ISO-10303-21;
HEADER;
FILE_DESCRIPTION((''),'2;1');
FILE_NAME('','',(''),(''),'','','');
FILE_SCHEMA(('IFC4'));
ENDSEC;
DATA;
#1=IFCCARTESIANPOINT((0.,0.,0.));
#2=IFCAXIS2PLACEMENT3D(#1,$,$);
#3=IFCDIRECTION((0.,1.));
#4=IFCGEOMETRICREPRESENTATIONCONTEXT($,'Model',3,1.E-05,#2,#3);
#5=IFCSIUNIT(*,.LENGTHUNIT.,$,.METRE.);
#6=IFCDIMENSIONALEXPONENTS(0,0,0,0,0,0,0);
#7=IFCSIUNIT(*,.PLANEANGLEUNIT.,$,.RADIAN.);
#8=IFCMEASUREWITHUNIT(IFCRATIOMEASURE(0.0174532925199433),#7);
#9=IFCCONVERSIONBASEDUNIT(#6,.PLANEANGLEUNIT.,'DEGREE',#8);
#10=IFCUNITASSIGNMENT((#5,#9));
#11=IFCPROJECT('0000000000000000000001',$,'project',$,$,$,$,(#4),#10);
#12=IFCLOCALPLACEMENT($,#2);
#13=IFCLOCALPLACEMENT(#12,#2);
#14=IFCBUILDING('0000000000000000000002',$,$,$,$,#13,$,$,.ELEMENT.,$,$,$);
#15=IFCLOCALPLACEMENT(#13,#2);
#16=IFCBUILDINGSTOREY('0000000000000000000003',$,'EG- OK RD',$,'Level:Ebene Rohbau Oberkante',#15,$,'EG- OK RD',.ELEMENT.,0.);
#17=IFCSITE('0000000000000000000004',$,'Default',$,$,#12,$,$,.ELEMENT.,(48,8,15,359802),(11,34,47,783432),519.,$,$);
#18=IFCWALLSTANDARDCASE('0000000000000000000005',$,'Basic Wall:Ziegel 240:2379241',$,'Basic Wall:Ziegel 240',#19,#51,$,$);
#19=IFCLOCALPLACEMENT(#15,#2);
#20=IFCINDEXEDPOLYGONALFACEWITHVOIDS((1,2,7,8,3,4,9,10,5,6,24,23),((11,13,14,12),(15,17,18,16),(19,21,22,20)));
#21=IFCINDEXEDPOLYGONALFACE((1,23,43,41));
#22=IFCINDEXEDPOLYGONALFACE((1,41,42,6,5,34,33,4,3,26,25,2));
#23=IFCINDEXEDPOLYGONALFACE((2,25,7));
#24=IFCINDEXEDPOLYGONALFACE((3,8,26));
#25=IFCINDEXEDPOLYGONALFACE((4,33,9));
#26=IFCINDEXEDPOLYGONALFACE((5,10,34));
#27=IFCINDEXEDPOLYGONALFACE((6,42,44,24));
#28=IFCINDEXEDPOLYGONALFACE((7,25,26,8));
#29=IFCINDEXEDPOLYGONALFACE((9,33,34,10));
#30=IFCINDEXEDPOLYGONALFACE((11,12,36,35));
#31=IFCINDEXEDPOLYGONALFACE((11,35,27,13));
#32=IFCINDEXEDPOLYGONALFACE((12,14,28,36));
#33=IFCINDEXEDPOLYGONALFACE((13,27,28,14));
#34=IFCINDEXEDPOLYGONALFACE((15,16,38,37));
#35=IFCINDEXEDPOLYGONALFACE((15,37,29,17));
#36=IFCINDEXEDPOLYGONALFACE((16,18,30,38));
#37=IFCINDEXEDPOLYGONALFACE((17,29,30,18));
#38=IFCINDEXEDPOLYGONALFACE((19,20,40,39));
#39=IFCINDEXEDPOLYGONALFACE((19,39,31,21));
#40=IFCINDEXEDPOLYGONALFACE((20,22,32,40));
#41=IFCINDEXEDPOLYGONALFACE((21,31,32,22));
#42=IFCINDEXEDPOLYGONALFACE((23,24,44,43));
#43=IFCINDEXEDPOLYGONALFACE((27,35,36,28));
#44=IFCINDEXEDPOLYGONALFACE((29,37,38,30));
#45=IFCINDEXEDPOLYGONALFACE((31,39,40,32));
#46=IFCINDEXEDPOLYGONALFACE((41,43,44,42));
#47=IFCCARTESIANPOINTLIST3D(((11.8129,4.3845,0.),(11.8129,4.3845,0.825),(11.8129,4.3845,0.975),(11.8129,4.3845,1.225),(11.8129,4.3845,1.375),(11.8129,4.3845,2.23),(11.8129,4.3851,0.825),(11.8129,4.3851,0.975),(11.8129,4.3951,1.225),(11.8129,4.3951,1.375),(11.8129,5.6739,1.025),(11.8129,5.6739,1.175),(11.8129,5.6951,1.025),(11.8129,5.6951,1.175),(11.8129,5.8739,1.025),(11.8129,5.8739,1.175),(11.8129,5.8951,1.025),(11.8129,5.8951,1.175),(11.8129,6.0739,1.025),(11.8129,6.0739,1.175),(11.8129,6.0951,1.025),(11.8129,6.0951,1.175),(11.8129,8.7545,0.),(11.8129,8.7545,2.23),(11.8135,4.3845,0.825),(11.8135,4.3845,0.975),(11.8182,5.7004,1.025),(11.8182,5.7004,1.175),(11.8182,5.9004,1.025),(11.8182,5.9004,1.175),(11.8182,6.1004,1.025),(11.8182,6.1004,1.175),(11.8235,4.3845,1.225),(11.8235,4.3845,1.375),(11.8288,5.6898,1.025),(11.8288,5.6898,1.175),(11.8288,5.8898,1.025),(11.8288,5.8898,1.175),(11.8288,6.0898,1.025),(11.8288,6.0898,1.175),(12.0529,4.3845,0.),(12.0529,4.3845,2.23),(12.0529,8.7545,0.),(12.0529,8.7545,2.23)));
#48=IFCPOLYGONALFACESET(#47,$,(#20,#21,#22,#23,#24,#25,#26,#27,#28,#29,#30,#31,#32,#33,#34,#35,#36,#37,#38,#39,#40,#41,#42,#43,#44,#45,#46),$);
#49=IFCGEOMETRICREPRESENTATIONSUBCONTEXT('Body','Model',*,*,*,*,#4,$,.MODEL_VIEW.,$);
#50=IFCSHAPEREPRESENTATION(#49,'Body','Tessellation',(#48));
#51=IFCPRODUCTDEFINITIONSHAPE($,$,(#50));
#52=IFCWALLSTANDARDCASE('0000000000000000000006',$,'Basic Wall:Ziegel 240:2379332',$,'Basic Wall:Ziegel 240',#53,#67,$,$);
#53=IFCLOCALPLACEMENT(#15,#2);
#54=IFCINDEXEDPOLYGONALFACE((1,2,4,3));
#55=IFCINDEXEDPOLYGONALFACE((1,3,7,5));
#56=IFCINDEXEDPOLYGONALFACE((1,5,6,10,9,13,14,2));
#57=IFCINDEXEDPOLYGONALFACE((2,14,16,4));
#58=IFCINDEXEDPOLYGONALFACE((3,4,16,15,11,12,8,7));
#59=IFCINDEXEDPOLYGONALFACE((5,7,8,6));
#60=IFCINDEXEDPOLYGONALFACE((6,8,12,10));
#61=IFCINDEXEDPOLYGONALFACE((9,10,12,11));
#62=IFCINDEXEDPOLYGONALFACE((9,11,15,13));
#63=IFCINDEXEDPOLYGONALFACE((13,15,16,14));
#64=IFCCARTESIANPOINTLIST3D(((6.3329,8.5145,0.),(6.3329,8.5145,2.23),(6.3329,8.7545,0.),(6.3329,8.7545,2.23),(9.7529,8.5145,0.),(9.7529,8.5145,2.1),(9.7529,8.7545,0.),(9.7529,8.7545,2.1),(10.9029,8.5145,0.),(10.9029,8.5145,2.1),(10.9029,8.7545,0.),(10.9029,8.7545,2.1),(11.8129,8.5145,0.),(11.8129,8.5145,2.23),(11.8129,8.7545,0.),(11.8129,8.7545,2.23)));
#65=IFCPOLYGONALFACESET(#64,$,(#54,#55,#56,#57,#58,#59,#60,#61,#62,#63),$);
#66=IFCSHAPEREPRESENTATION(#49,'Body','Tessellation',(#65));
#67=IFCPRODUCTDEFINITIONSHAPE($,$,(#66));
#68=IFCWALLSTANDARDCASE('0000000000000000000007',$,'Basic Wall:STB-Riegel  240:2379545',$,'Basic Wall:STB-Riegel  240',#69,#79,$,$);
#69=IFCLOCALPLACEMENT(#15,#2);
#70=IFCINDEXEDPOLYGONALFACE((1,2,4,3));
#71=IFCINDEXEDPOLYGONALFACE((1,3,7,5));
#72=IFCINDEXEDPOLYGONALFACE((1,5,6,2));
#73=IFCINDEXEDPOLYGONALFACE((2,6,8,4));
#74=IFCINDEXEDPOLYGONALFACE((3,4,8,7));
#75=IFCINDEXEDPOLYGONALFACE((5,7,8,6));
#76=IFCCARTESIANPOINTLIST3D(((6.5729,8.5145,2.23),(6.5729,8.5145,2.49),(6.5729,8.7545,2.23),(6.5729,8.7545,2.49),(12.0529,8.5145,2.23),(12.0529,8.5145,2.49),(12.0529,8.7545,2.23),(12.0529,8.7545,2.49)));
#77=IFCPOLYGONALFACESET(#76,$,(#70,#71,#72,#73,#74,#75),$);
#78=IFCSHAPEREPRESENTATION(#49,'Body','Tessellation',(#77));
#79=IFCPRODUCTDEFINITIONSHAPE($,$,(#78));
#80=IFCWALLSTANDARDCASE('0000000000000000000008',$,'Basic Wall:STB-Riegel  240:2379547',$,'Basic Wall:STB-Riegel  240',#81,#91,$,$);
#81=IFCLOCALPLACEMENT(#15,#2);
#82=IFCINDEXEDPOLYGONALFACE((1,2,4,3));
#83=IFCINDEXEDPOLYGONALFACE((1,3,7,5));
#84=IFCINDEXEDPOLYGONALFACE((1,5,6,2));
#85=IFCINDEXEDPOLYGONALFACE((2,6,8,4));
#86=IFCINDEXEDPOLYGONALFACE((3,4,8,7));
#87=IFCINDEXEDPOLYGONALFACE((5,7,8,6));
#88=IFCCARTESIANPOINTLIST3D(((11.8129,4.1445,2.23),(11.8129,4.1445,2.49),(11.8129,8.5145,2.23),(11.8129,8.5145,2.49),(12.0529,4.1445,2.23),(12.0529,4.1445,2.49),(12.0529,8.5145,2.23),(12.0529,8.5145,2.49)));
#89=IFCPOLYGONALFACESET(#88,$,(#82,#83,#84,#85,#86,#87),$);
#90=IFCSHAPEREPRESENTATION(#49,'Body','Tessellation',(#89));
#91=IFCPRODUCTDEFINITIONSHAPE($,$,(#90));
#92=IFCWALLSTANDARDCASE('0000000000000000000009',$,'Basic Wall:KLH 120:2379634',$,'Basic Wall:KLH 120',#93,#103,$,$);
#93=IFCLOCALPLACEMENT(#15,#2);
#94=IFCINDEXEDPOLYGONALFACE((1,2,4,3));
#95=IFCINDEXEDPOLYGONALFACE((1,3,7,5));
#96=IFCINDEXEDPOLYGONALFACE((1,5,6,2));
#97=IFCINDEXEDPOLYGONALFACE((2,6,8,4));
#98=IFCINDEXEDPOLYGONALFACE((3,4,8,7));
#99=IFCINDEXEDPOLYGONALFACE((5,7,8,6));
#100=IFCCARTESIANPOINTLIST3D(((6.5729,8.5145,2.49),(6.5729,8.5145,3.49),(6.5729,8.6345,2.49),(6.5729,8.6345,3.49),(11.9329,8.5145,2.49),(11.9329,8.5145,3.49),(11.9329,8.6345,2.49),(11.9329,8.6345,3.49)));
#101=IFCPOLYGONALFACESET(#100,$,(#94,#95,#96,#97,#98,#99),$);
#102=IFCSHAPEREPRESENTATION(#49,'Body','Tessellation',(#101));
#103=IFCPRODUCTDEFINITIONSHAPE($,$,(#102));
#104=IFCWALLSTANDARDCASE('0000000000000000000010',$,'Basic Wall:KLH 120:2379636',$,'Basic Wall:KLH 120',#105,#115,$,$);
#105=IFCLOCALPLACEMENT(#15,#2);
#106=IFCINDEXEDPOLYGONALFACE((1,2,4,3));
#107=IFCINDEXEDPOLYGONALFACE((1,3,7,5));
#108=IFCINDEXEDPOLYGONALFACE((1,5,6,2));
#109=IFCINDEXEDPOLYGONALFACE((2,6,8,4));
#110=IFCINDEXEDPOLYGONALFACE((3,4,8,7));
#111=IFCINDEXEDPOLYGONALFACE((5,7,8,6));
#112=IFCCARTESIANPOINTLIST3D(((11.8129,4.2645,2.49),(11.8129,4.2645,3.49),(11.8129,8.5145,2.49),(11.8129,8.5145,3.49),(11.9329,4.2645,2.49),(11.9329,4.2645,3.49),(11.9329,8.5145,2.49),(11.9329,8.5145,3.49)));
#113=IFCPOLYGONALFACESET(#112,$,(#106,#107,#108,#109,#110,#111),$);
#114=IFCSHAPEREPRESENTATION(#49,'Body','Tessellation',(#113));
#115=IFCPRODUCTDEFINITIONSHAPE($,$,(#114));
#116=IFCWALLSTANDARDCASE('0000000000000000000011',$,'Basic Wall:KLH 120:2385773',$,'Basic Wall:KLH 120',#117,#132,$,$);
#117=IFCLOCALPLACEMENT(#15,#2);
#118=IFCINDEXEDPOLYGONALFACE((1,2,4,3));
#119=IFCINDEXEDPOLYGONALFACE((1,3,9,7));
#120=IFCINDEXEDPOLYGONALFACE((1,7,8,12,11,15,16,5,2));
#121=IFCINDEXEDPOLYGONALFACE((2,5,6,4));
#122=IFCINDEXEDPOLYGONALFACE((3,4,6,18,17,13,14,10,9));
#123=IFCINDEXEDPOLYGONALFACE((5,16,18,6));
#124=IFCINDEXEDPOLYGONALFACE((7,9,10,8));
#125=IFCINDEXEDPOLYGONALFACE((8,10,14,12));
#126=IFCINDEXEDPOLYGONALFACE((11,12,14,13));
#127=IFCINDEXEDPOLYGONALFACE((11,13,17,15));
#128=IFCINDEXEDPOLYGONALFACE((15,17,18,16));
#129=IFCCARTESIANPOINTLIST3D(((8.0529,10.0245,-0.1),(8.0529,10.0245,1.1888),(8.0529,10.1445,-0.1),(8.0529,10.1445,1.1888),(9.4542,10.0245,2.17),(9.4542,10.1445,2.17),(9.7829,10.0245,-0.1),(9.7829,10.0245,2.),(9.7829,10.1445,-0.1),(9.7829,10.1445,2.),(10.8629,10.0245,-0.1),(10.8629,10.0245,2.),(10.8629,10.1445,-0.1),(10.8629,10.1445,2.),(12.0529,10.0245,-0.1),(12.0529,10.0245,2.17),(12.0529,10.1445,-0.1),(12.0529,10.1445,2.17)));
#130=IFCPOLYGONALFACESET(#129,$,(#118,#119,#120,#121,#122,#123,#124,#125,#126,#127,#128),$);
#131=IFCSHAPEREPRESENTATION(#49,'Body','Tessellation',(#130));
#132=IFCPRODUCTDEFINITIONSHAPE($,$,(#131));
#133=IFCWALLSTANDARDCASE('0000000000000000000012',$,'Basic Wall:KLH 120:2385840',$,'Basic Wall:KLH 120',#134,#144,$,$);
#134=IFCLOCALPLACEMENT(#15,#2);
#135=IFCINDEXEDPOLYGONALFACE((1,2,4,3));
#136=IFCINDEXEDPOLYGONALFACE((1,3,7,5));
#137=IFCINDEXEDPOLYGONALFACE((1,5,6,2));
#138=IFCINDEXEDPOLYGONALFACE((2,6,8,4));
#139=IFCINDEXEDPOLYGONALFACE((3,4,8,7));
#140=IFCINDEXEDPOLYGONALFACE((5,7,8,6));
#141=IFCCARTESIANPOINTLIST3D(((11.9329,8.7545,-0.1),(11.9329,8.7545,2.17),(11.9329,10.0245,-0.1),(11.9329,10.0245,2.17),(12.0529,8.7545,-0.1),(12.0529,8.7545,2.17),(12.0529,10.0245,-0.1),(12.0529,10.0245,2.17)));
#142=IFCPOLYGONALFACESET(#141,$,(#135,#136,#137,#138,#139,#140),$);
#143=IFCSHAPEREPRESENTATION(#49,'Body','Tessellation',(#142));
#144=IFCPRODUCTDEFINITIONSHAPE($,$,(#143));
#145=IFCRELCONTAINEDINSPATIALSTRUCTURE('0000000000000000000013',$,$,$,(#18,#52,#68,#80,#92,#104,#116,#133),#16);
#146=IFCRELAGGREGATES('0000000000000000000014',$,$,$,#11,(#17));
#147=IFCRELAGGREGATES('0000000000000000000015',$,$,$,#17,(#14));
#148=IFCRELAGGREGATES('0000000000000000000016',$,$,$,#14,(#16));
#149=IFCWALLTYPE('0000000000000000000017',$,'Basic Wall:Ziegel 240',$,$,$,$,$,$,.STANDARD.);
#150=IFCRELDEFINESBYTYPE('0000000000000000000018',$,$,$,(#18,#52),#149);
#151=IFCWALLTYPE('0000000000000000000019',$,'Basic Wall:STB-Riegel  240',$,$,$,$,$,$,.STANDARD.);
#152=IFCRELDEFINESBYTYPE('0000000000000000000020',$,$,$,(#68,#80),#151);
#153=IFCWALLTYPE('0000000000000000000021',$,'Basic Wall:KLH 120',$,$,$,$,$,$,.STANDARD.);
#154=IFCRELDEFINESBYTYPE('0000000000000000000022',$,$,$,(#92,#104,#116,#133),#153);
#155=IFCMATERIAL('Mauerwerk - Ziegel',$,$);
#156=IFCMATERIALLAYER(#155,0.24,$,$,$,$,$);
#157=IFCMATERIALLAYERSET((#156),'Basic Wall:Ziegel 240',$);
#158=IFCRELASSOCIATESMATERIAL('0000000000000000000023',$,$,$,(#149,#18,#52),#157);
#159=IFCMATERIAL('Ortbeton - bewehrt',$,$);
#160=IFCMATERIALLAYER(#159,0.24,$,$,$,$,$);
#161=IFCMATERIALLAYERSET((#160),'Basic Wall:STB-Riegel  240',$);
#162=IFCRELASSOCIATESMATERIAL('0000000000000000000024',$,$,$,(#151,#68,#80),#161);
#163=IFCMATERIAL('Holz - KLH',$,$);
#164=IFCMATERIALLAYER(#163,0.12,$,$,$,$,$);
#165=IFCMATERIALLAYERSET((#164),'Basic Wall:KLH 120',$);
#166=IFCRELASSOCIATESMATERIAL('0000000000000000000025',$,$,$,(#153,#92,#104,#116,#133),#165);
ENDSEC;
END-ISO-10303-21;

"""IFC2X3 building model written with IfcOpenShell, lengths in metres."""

from ifc_helpers import new_model, entity, si_unit, converted_unit, direction, frame, frame_2d, origin, place, context, subcontext, project, spatial, polyline, rectangle, extrude, clip, bounded_halfspace, material, layer, layer_set, layer_usage, type_object, element, save


model = new_model("IFC2X3")

# Units and contexts
model_context = context("Model", 3, precision=1e-05, world=origin(), true_north=direction((0.0, 1.0)))
body_context = subcontext(model_context, "Body", "Model", "MODEL_VIEW")
ifc_project = project(units=[si_unit("LENGTHUNIT", "METRE"), converted_unit("PLANEANGLEUNIT", "DEGREE", entity("IfcRatioMeasure", 0.0174532925199433), si_unit("PLANEANGLEUNIT", "RADIAN"), dimensions=[0, 0, 0, 0, 0, 0, 0])], contexts=[model_context])

# Site, building, storey
site_placement = place(None, origin())
site = spatial("IfcSite", under=ifc_project, at=site_placement, Name="Default", CompositionType="ELEMENT", RefLatitude=(48, 8, 15, 359802), RefLongitude=(11, 34, 47, 783432), RefElevation=519.0)
building_placement = place(site_placement, origin())
building = spatial("IfcBuilding", under=site, at=building_placement, CompositionType="ELEMENT")
storey_placement = place(building_placement, origin())
storey = spatial("IfcBuildingStorey", under=building, at=storey_placement, Name="EG- OK RD", ObjectType="Level:Ebene Rohbau Oberkante", LongName="EG- OK RD", CompositionType="ELEMENT", Elevation=0.0)

# Wall, openings
ifc_material_1 = material(Name="Mauerwerk - Ziegel")
ifc_layer_1 = layer(ifc_material_1, 0.24)
ifc_layer_set_1 = layer_set([ifc_layer_1], Name="Basic Wall:Ziegel 240")
ifc_layer_usage_1 = layer_usage(ifc_layer_set_1, "AXIS2", "POSITIVE", -0.12)
wall_type_1 = type_object("IfcWallType", Name="Basic Wall:Ziegel 240", PredefinedType="STANDARD", material=ifc_layer_set_1)
wall_1_placement = place(storey_placement, frame((11.9329, 4.3845, 0.0), z_axis=(0.0, 0.0, 1.0), x_axis=(0.0, 1.0, 0.0)))
wall_1 = element("IfcWallStandardCase", 1, at=wall_1_placement, inside=storey, type_object=wall_type_1, material=ifc_layer_usage_1, Name="Basic Wall:Ziegel 240:2379241", ObjectType="Basic Wall:Ziegel 240", context=body_context, shape_type="SweptSolid", body=[
    extrude(rectangle(XDim=4.37, YDim=0.24, at=frame_2d((2.185, 0.0), x_axis=(-1.0, 0.0))), origin(), (0.0, 0.0, 1.0), 2.23),
])
opening_1_placement = place(wall_1_placement, origin())
element("IfcOpeningElement", 2, at=opening_1_placement, cuts=wall_1, ObjectType="Recess", context=body_context, shape_type="SweptSolid", body=[
    extrude(rectangle(XDim=0.15, YDim=0.0285, at=frame_2d((0.0, 0.0), x_axis=(0.0, 1.0))), frame((0.0048, 0.1242, 0.9), z_axis=(-0.707107, 0.707107, 0.0), x_axis=(-0.707107, -0.707107, 0.0)), (0.0, 0.0, 1.0), 0.015),
])
opening_2_placement = place(wall_1_placement, origin())
element("IfcOpeningElement", 3, at=opening_2_placement, cuts=wall_1, ObjectType="Recess", context=body_context, shape_type="SweptSolid", body=[
    extrude(rectangle(XDim=0.15, YDim=0.0285, at=frame_2d((0.0, 0.0), x_axis=(0.0, 1.0))), frame((0.0048, 0.1142, 1.3), z_axis=(-0.707107, 0.707107, 0.0), x_axis=(-0.707107, -0.707107, 0.0)), (0.0, 0.0, 1.0), 0.015),
])
opening_3_placement = place(wall_1_placement, origin())
element("IfcOpeningElement", 4, at=opening_3_placement, cuts=wall_1, ObjectType="Recess", context=body_context, shape_type="SweptSolid", body=[
    extrude(rectangle(XDim=0.15, YDim=0.0285, at=frame_2d((0.0, 0.0), x_axis=(0.0, 1.0))), frame((0.1195, 0.2289, 1.1), z_axis=(-0.707107, 0.707107, 0.0), x_axis=(-0.707107, -0.707107, 0.0)), (0.0, 0.0, 1.0), 0.015),
])
opening_4_placement = place(wall_1_placement, origin())
element("IfcOpeningElement", 5, at=opening_4_placement, cuts=wall_1, ObjectType="Recess", context=body_context, shape_type="SweptSolid", body=[
    extrude(rectangle(XDim=0.15, YDim=0.0285, at=frame_2d((0.0, 0.0), x_axis=(0.0, 1.0))), frame((1.2952, 0.1142, 1.1), z_axis=(0.707107, 0.707107, 0.0), x_axis=(0.707107, -0.707107, 0.0)), (0.0, 0.0, 1.0), 0.015),
])
opening_5_placement = place(wall_1_placement, origin())
element("IfcOpeningElement", 6, at=opening_5_placement, cuts=wall_1, ObjectType="Recess", context=body_context, shape_type="SweptSolid", body=[
    extrude(rectangle(XDim=0.15, YDim=0.0285, at=frame_2d((0.0, 0.0), x_axis=(0.0, 1.0))), frame((1.4952, 0.1142, 1.1), z_axis=(0.707107, 0.707107, 0.0), x_axis=(0.707107, -0.707107, 0.0)), (0.0, 0.0, 1.0), 0.015),
])
opening_6_placement = place(wall_1_placement, origin())
element("IfcOpeningElement", 7, at=opening_6_placement, cuts=wall_1, ObjectType="Recess", context=body_context, shape_type="SweptSolid", body=[
    extrude(rectangle(XDim=0.15, YDim=0.0285, at=frame_2d((0.0, 0.0), x_axis=(0.0, 1.0))), frame((1.6952, 0.1142, 1.1), z_axis=(0.707107, 0.707107, 0.0), x_axis=(0.707107, -0.707107, 0.0)), (0.0, 0.0, 1.0), 0.015),
])

# Wall, opening
ifc_layer_usage_2 = layer_usage(ifc_layer_set_1, "AXIS2", "POSITIVE", -0.12)
wall_2_placement = place(storey_placement, frame((11.8129, 8.6345, 0.0), z_axis=(0.0, 0.0, 1.0), x_axis=(-1.0, 0.0, 0.0)))
wall_2 = element("IfcWallStandardCase", 8, at=wall_2_placement, inside=storey, type_object=wall_type_1, material=ifc_layer_usage_2, Name="Basic Wall:Ziegel 240:2379332", ObjectType="Basic Wall:Ziegel 240", context=body_context, shape_type="SweptSolid", body=[
    extrude(rectangle(XDim=5.48, YDim=0.24, at=frame_2d((2.74, 0.0), x_axis=(-1.0, 0.0))), origin(), (0.0, 0.0, 1.0), 2.23),
])
opening_7_placement = place(wall_2_placement, frame((0.91, -0.12, 0.0)))
element("IfcOpeningElement", 9, at=opening_7_placement, cuts=wall_2, ObjectType="Opening", context=body_context, shape_type="SweptSolid", body=[
    extrude(rectangle(XDim=2.1, YDim=1.15, at=frame_2d((1.05, 0.575), x_axis=(-1.0, 0.0))), frame((0.0, 0.0, 0.0), z_axis=(0.0, 1.0, 0.0), x_axis=(0.0, 0.0, 1.0)), (0.0, 0.0, 1.0), 0.24),
])

# Walls
ifc_material_2 = material(Name="Ortbeton - bewehrt")
ifc_layer_2 = layer(ifc_material_2, 0.24)
ifc_layer_set_2 = layer_set([ifc_layer_2], Name="Basic Wall:STB-Riegel  240")
ifc_layer_usage_3 = layer_usage(ifc_layer_set_2, "AXIS2", "NEGATIVE", 0.12)
wall_type_2 = type_object("IfcWallType", Name="Basic Wall:STB-Riegel  240", PredefinedType="STANDARD", material=ifc_layer_set_2)
wall_3_placement = place(storey_placement, frame((12.0529, 8.6345, 2.23), z_axis=(0.0, 0.0, 1.0), x_axis=(-1.0, 0.0, 0.0)))
element("IfcWallStandardCase", 10, at=wall_3_placement, inside=storey, type_object=wall_type_2, material=ifc_layer_usage_3, Name="Basic Wall:STB-Riegel  240:2379545", ObjectType="Basic Wall:STB-Riegel  240", context=body_context, shape_type="SweptSolid", body=[
    extrude(rectangle(XDim=5.48, YDim=0.24, at=frame_2d((2.74, 0.0), x_axis=(-1.0, 0.0))), origin(), (0.0, 0.0, 1.0), 0.26),
])
ifc_layer_usage_4 = layer_usage(ifc_layer_set_2, "AXIS2", "NEGATIVE", 0.12)
wall_4_placement = place(storey_placement, frame((11.9329, 4.1445, 2.23), z_axis=(0.0, 0.0, 1.0), x_axis=(0.0, 1.0, 0.0)))
element("IfcWallStandardCase", 11, at=wall_4_placement, inside=storey, type_object=wall_type_2, material=ifc_layer_usage_4, Name="Basic Wall:STB-Riegel  240:2379547", ObjectType="Basic Wall:STB-Riegel  240", context=body_context, shape_type="SweptSolid", body=[
    extrude(rectangle(XDim=4.37, YDim=0.24, at=frame_2d((2.185, 0.0), x_axis=(-1.0, 0.0))), origin(), (0.0, 0.0, 1.0), 0.26),
])
ifc_material_3 = material(Name="Holz - KLH")
ifc_layer_3 = layer(ifc_material_3, 0.12)
ifc_layer_set_3 = layer_set([ifc_layer_3], Name="Basic Wall:KLH 120")
ifc_layer_usage_5 = layer_usage(ifc_layer_set_3, "AXIS2", "NEGATIVE", 0.06)
wall_type_3 = type_object("IfcWallType", Name="Basic Wall:KLH 120", PredefinedType="STANDARD", material=ifc_layer_set_3)
wall_5_placement = place(storey_placement, frame((11.9329, 8.5745, 2.49), z_axis=(0.0, 0.0, 1.0), x_axis=(-1.0, 0.0, 0.0)))
element("IfcWallStandardCase", 12, at=wall_5_placement, inside=storey, type_object=wall_type_3, material=ifc_layer_usage_5, Name="Basic Wall:KLH 120:2379634", ObjectType="Basic Wall:KLH 120", context=body_context, shape_type="SweptSolid", body=[
    extrude(rectangle(XDim=5.36, YDim=0.12, at=frame_2d((2.68, 0.0), x_axis=(-1.0, 0.0))), origin(), (0.0, 0.0, 1.0), 1.0),
])
ifc_layer_usage_6 = layer_usage(ifc_layer_set_3, "AXIS2", "NEGATIVE", 0.06)
wall_6_placement = place(storey_placement, frame((11.8729, 4.2645, 2.49), z_axis=(0.0, 0.0, 1.0), x_axis=(0.0, 1.0, 0.0)))
element("IfcWallStandardCase", 13, at=wall_6_placement, inside=storey, type_object=wall_type_3, material=ifc_layer_usage_6, Name="Basic Wall:KLH 120:2379636", ObjectType="Basic Wall:KLH 120", context=body_context, shape_type="SweptSolid", body=[
    extrude(rectangle(XDim=4.25, YDim=0.12, at=frame_2d((2.125, 0.0), x_axis=(-1.0, 0.0))), origin(), (0.0, 0.0, 1.0), 1.0),
])

# Wall, opening
ifc_layer_usage_7 = layer_usage(ifc_layer_set_3, "AXIS2", "POSITIVE", -0.06)
wall_7_placement = place(storey_placement, frame((12.0529, 10.0845, -0.1), z_axis=(0.0, 0.0, 1.0), x_axis=(-1.0, 0.0, 0.0)))
wall_7 = element("IfcWallStandardCase", 14, at=wall_7_placement, inside=storey, type_object=wall_type_3, material=ifc_layer_usage_7, Name="Basic Wall:KLH 120:2385773", ObjectType="Basic Wall:KLH 120", context=body_context, shape_type="Clipping", body=[
    clip(clip(extrude(rectangle(XDim=4.0, YDim=0.12, at=frame_2d((2.0, 0.0), x_axis=(-1.0, 0.0))), origin(), (0.0, 0.0, 1.0), 2.27), bounded_halfspace(frame((0.0, 0.06, 2.27), z_axis=(0.0, 0.0, -1.0), x_axis=(0.0, 1.0, 0.0)), True, frame((0.0, 0.06, 2.27)), polyline([(0.0, 0.0), (0.0, -0.12), (2.5987, -0.12), (2.5987, 0.0), (0.12, 0.0), (0.0, 0.0)]))), bounded_halfspace(frame((4.0, -0.06, 1.2888), z_axis=(-0.573576, 0.0, -0.819152), x_axis=(0.0, 1.0, 0.0)), True, frame((4.0, -0.06, 1.2888)), polyline([(0.0, 0.0), (0.0, 0.12), (-0.12, 0.12), (-1.4013, 0.12), (-1.4013, 0.0), (0.0, 0.0)]))),
])
opening_8_placement = place(wall_7_placement, frame((1.19, -0.06, 0.0)))
element("IfcOpeningElement", 15, at=opening_8_placement, cuts=wall_7, ObjectType="Opening", context=body_context, shape_type="SweptSolid", body=[
    extrude(rectangle(XDim=2.1, YDim=1.08, at=frame_2d((1.05, 0.54), x_axis=(-1.0, 0.0))), frame((0.0, 0.0, 0.0), z_axis=(0.0, 1.0, 0.0), x_axis=(0.0, 0.0, 1.0)), (0.0, 0.0, 1.0), 0.12),
])

# Wall
ifc_layer_usage_8 = layer_usage(ifc_layer_set_3, "AXIS2", "POSITIVE", -0.06)
wall_8_placement = place(storey_placement, frame((11.9929, 8.7545, -0.1), z_axis=(0.0, 0.0, 1.0), x_axis=(0.0, 1.0, 0.0)))
element("IfcWallStandardCase", 16, at=wall_8_placement, inside=storey, type_object=wall_type_3, material=ifc_layer_usage_8, Name="Basic Wall:KLH 120:2385840", ObjectType="Basic Wall:KLH 120", context=body_context, shape_type="Clipping", body=[
    clip(extrude(rectangle(XDim=1.27, YDim=0.12, at=frame_2d((0.635, 0.0), x_axis=(-1.0, 0.0))), origin(), (0.0, 0.0, 1.0), 2.27), bounded_halfspace(frame((0.0, -0.06, 2.27), z_axis=(0.0, 0.0, -1.0), x_axis=(-1.0, 0.0, 0.0)), True, frame((0.0, -0.06, 2.27)), polyline([(0.0, 0.0), (1.27, 0.0), (1.27, 0.12), (0.0, 0.12), (0.0, 0.0)]))),
])

save(model, "model.ifc")
